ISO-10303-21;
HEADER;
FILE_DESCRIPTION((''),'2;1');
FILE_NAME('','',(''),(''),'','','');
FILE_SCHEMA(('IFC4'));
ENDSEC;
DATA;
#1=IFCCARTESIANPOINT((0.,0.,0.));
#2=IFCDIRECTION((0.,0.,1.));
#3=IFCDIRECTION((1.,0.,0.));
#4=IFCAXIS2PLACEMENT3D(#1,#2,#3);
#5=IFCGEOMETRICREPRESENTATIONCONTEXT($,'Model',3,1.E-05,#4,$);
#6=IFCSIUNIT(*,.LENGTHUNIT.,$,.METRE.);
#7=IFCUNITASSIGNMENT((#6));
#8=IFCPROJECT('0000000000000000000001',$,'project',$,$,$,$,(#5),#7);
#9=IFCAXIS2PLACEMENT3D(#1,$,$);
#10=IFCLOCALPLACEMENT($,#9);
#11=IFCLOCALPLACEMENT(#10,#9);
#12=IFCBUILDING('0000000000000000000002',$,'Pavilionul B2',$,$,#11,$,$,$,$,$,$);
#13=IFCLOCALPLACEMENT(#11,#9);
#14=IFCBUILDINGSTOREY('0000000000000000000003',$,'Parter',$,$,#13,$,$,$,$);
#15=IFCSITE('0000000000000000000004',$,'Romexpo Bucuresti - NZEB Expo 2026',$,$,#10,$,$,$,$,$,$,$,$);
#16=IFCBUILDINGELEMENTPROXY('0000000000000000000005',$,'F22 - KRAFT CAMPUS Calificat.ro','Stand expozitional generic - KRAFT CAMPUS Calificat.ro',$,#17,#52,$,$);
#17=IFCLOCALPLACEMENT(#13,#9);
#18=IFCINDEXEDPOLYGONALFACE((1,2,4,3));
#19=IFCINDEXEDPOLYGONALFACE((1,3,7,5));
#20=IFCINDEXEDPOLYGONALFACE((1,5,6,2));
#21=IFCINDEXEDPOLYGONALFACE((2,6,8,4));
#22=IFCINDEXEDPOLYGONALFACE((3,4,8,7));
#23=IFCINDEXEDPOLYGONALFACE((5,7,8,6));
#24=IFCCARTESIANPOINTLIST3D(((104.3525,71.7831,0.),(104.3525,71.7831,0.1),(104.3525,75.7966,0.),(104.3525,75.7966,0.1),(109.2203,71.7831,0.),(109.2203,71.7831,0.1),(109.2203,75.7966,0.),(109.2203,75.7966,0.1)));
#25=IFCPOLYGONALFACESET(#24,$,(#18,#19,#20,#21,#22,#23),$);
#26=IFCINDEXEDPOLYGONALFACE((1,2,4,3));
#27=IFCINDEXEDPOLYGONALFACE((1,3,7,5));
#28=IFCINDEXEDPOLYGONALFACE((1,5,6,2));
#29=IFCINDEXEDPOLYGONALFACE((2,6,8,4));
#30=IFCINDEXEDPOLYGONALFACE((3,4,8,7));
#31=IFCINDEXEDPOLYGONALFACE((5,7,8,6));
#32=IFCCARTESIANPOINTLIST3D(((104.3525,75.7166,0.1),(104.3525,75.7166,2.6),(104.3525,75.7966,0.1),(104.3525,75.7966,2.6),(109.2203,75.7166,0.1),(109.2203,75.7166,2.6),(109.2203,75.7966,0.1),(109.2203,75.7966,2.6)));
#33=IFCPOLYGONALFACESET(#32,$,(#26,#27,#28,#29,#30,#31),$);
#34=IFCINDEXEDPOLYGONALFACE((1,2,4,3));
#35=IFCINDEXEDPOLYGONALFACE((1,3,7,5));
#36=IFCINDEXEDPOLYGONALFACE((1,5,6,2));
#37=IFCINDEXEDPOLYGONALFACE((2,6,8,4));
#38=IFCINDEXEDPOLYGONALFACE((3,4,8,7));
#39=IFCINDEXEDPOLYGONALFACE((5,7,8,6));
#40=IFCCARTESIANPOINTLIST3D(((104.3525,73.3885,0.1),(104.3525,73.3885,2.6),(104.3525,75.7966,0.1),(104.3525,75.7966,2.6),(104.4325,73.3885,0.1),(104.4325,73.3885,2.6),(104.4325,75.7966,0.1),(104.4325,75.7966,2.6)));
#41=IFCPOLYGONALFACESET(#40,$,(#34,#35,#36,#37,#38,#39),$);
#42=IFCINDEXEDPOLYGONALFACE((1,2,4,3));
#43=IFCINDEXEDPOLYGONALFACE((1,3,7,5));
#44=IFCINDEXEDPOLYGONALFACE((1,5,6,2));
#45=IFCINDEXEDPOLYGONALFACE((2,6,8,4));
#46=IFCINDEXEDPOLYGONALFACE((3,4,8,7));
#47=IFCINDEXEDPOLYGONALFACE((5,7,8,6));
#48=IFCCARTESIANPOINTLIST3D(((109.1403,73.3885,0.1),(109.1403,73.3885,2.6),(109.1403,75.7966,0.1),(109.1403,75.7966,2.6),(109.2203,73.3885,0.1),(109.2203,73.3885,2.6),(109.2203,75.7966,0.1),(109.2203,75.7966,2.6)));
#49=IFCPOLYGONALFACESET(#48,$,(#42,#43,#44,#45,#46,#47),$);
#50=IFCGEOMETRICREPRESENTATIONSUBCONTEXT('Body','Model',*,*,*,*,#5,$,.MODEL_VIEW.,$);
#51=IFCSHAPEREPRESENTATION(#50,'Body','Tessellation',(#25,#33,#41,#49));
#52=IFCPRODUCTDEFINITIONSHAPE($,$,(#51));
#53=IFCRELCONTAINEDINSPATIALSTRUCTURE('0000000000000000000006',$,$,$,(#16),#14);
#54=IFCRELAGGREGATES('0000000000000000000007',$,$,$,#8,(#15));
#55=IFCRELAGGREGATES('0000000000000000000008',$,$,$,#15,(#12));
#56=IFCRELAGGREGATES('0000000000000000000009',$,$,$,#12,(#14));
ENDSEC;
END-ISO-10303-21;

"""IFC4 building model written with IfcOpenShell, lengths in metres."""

from ifc_helpers import new_model, si_unit, frame, frame_2d, origin, origin_with_axes, place, context, subcontext, project, spatial, rectangle, extrude, element, save


model = new_model("IFC4")

# Units and contexts
model_context = context("Model", 3, precision=1e-05, world=origin_with_axes())
body_context = subcontext(model_context, "Body", "Model", "MODEL_VIEW")
ifc_project = project(units=[si_unit("LENGTHUNIT", "METRE")], contexts=[model_context])

# Site, building, storey
site_placement = place(None, origin())
site = spatial("IfcSite", under=ifc_project, at=site_placement, Name="Romexpo Bucuresti - NZEB Expo 2026")
building_placement = place(site_placement, origin())
building = spatial("IfcBuilding", under=site, at=building_placement, Name="Pavilionul B2")
storey_placement = place(building_placement, origin())
storey = spatial("IfcBuildingStorey", under=building, at=storey_placement, Name="Parter")

# Building element proxy
proxy_1_placement = place(storey_placement, frame((104.3525, 71.7831, 0.0), z_axis=(0.0, 0.0, 1.0), x_axis=(1.0, 0.0, 0.0)))
element("IfcBuildingElementProxy", 1, at=proxy_1_placement, inside=storey, Name="F22 - KRAFT CAMPUS Calificat.ro", Description="Stand expozitional generic - KRAFT CAMPUS Calificat.ro", context=body_context, shape_type="SweptSolid", body=[
    extrude(rectangle(XDim=4.8678, YDim=4.0136, at=frame_2d((2.4339, 2.0068))), origin(), (0.0, 0.0, 1.0), 0.1),
    extrude(rectangle(XDim=4.8678, YDim=0.08, at=frame_2d((2.4339, 3.9736))), frame((0.0, 0.0, 0.1)), (0.0, 0.0, 1.0), 2.5),
    extrude(rectangle(XDim=0.08, YDim=2.4081, at=frame_2d((0.04, 2.8095))), frame((0.0, 0.0, 0.1)), (0.0, 0.0, 1.0), 2.5),
    extrude(rectangle(XDim=0.08, YDim=2.4081, at=frame_2d((4.8278, 2.8095))), frame((0.0, 0.0, 0.1)), (0.0, 0.0, 1.0), 2.5),
])

save(model, "model.ifc")
